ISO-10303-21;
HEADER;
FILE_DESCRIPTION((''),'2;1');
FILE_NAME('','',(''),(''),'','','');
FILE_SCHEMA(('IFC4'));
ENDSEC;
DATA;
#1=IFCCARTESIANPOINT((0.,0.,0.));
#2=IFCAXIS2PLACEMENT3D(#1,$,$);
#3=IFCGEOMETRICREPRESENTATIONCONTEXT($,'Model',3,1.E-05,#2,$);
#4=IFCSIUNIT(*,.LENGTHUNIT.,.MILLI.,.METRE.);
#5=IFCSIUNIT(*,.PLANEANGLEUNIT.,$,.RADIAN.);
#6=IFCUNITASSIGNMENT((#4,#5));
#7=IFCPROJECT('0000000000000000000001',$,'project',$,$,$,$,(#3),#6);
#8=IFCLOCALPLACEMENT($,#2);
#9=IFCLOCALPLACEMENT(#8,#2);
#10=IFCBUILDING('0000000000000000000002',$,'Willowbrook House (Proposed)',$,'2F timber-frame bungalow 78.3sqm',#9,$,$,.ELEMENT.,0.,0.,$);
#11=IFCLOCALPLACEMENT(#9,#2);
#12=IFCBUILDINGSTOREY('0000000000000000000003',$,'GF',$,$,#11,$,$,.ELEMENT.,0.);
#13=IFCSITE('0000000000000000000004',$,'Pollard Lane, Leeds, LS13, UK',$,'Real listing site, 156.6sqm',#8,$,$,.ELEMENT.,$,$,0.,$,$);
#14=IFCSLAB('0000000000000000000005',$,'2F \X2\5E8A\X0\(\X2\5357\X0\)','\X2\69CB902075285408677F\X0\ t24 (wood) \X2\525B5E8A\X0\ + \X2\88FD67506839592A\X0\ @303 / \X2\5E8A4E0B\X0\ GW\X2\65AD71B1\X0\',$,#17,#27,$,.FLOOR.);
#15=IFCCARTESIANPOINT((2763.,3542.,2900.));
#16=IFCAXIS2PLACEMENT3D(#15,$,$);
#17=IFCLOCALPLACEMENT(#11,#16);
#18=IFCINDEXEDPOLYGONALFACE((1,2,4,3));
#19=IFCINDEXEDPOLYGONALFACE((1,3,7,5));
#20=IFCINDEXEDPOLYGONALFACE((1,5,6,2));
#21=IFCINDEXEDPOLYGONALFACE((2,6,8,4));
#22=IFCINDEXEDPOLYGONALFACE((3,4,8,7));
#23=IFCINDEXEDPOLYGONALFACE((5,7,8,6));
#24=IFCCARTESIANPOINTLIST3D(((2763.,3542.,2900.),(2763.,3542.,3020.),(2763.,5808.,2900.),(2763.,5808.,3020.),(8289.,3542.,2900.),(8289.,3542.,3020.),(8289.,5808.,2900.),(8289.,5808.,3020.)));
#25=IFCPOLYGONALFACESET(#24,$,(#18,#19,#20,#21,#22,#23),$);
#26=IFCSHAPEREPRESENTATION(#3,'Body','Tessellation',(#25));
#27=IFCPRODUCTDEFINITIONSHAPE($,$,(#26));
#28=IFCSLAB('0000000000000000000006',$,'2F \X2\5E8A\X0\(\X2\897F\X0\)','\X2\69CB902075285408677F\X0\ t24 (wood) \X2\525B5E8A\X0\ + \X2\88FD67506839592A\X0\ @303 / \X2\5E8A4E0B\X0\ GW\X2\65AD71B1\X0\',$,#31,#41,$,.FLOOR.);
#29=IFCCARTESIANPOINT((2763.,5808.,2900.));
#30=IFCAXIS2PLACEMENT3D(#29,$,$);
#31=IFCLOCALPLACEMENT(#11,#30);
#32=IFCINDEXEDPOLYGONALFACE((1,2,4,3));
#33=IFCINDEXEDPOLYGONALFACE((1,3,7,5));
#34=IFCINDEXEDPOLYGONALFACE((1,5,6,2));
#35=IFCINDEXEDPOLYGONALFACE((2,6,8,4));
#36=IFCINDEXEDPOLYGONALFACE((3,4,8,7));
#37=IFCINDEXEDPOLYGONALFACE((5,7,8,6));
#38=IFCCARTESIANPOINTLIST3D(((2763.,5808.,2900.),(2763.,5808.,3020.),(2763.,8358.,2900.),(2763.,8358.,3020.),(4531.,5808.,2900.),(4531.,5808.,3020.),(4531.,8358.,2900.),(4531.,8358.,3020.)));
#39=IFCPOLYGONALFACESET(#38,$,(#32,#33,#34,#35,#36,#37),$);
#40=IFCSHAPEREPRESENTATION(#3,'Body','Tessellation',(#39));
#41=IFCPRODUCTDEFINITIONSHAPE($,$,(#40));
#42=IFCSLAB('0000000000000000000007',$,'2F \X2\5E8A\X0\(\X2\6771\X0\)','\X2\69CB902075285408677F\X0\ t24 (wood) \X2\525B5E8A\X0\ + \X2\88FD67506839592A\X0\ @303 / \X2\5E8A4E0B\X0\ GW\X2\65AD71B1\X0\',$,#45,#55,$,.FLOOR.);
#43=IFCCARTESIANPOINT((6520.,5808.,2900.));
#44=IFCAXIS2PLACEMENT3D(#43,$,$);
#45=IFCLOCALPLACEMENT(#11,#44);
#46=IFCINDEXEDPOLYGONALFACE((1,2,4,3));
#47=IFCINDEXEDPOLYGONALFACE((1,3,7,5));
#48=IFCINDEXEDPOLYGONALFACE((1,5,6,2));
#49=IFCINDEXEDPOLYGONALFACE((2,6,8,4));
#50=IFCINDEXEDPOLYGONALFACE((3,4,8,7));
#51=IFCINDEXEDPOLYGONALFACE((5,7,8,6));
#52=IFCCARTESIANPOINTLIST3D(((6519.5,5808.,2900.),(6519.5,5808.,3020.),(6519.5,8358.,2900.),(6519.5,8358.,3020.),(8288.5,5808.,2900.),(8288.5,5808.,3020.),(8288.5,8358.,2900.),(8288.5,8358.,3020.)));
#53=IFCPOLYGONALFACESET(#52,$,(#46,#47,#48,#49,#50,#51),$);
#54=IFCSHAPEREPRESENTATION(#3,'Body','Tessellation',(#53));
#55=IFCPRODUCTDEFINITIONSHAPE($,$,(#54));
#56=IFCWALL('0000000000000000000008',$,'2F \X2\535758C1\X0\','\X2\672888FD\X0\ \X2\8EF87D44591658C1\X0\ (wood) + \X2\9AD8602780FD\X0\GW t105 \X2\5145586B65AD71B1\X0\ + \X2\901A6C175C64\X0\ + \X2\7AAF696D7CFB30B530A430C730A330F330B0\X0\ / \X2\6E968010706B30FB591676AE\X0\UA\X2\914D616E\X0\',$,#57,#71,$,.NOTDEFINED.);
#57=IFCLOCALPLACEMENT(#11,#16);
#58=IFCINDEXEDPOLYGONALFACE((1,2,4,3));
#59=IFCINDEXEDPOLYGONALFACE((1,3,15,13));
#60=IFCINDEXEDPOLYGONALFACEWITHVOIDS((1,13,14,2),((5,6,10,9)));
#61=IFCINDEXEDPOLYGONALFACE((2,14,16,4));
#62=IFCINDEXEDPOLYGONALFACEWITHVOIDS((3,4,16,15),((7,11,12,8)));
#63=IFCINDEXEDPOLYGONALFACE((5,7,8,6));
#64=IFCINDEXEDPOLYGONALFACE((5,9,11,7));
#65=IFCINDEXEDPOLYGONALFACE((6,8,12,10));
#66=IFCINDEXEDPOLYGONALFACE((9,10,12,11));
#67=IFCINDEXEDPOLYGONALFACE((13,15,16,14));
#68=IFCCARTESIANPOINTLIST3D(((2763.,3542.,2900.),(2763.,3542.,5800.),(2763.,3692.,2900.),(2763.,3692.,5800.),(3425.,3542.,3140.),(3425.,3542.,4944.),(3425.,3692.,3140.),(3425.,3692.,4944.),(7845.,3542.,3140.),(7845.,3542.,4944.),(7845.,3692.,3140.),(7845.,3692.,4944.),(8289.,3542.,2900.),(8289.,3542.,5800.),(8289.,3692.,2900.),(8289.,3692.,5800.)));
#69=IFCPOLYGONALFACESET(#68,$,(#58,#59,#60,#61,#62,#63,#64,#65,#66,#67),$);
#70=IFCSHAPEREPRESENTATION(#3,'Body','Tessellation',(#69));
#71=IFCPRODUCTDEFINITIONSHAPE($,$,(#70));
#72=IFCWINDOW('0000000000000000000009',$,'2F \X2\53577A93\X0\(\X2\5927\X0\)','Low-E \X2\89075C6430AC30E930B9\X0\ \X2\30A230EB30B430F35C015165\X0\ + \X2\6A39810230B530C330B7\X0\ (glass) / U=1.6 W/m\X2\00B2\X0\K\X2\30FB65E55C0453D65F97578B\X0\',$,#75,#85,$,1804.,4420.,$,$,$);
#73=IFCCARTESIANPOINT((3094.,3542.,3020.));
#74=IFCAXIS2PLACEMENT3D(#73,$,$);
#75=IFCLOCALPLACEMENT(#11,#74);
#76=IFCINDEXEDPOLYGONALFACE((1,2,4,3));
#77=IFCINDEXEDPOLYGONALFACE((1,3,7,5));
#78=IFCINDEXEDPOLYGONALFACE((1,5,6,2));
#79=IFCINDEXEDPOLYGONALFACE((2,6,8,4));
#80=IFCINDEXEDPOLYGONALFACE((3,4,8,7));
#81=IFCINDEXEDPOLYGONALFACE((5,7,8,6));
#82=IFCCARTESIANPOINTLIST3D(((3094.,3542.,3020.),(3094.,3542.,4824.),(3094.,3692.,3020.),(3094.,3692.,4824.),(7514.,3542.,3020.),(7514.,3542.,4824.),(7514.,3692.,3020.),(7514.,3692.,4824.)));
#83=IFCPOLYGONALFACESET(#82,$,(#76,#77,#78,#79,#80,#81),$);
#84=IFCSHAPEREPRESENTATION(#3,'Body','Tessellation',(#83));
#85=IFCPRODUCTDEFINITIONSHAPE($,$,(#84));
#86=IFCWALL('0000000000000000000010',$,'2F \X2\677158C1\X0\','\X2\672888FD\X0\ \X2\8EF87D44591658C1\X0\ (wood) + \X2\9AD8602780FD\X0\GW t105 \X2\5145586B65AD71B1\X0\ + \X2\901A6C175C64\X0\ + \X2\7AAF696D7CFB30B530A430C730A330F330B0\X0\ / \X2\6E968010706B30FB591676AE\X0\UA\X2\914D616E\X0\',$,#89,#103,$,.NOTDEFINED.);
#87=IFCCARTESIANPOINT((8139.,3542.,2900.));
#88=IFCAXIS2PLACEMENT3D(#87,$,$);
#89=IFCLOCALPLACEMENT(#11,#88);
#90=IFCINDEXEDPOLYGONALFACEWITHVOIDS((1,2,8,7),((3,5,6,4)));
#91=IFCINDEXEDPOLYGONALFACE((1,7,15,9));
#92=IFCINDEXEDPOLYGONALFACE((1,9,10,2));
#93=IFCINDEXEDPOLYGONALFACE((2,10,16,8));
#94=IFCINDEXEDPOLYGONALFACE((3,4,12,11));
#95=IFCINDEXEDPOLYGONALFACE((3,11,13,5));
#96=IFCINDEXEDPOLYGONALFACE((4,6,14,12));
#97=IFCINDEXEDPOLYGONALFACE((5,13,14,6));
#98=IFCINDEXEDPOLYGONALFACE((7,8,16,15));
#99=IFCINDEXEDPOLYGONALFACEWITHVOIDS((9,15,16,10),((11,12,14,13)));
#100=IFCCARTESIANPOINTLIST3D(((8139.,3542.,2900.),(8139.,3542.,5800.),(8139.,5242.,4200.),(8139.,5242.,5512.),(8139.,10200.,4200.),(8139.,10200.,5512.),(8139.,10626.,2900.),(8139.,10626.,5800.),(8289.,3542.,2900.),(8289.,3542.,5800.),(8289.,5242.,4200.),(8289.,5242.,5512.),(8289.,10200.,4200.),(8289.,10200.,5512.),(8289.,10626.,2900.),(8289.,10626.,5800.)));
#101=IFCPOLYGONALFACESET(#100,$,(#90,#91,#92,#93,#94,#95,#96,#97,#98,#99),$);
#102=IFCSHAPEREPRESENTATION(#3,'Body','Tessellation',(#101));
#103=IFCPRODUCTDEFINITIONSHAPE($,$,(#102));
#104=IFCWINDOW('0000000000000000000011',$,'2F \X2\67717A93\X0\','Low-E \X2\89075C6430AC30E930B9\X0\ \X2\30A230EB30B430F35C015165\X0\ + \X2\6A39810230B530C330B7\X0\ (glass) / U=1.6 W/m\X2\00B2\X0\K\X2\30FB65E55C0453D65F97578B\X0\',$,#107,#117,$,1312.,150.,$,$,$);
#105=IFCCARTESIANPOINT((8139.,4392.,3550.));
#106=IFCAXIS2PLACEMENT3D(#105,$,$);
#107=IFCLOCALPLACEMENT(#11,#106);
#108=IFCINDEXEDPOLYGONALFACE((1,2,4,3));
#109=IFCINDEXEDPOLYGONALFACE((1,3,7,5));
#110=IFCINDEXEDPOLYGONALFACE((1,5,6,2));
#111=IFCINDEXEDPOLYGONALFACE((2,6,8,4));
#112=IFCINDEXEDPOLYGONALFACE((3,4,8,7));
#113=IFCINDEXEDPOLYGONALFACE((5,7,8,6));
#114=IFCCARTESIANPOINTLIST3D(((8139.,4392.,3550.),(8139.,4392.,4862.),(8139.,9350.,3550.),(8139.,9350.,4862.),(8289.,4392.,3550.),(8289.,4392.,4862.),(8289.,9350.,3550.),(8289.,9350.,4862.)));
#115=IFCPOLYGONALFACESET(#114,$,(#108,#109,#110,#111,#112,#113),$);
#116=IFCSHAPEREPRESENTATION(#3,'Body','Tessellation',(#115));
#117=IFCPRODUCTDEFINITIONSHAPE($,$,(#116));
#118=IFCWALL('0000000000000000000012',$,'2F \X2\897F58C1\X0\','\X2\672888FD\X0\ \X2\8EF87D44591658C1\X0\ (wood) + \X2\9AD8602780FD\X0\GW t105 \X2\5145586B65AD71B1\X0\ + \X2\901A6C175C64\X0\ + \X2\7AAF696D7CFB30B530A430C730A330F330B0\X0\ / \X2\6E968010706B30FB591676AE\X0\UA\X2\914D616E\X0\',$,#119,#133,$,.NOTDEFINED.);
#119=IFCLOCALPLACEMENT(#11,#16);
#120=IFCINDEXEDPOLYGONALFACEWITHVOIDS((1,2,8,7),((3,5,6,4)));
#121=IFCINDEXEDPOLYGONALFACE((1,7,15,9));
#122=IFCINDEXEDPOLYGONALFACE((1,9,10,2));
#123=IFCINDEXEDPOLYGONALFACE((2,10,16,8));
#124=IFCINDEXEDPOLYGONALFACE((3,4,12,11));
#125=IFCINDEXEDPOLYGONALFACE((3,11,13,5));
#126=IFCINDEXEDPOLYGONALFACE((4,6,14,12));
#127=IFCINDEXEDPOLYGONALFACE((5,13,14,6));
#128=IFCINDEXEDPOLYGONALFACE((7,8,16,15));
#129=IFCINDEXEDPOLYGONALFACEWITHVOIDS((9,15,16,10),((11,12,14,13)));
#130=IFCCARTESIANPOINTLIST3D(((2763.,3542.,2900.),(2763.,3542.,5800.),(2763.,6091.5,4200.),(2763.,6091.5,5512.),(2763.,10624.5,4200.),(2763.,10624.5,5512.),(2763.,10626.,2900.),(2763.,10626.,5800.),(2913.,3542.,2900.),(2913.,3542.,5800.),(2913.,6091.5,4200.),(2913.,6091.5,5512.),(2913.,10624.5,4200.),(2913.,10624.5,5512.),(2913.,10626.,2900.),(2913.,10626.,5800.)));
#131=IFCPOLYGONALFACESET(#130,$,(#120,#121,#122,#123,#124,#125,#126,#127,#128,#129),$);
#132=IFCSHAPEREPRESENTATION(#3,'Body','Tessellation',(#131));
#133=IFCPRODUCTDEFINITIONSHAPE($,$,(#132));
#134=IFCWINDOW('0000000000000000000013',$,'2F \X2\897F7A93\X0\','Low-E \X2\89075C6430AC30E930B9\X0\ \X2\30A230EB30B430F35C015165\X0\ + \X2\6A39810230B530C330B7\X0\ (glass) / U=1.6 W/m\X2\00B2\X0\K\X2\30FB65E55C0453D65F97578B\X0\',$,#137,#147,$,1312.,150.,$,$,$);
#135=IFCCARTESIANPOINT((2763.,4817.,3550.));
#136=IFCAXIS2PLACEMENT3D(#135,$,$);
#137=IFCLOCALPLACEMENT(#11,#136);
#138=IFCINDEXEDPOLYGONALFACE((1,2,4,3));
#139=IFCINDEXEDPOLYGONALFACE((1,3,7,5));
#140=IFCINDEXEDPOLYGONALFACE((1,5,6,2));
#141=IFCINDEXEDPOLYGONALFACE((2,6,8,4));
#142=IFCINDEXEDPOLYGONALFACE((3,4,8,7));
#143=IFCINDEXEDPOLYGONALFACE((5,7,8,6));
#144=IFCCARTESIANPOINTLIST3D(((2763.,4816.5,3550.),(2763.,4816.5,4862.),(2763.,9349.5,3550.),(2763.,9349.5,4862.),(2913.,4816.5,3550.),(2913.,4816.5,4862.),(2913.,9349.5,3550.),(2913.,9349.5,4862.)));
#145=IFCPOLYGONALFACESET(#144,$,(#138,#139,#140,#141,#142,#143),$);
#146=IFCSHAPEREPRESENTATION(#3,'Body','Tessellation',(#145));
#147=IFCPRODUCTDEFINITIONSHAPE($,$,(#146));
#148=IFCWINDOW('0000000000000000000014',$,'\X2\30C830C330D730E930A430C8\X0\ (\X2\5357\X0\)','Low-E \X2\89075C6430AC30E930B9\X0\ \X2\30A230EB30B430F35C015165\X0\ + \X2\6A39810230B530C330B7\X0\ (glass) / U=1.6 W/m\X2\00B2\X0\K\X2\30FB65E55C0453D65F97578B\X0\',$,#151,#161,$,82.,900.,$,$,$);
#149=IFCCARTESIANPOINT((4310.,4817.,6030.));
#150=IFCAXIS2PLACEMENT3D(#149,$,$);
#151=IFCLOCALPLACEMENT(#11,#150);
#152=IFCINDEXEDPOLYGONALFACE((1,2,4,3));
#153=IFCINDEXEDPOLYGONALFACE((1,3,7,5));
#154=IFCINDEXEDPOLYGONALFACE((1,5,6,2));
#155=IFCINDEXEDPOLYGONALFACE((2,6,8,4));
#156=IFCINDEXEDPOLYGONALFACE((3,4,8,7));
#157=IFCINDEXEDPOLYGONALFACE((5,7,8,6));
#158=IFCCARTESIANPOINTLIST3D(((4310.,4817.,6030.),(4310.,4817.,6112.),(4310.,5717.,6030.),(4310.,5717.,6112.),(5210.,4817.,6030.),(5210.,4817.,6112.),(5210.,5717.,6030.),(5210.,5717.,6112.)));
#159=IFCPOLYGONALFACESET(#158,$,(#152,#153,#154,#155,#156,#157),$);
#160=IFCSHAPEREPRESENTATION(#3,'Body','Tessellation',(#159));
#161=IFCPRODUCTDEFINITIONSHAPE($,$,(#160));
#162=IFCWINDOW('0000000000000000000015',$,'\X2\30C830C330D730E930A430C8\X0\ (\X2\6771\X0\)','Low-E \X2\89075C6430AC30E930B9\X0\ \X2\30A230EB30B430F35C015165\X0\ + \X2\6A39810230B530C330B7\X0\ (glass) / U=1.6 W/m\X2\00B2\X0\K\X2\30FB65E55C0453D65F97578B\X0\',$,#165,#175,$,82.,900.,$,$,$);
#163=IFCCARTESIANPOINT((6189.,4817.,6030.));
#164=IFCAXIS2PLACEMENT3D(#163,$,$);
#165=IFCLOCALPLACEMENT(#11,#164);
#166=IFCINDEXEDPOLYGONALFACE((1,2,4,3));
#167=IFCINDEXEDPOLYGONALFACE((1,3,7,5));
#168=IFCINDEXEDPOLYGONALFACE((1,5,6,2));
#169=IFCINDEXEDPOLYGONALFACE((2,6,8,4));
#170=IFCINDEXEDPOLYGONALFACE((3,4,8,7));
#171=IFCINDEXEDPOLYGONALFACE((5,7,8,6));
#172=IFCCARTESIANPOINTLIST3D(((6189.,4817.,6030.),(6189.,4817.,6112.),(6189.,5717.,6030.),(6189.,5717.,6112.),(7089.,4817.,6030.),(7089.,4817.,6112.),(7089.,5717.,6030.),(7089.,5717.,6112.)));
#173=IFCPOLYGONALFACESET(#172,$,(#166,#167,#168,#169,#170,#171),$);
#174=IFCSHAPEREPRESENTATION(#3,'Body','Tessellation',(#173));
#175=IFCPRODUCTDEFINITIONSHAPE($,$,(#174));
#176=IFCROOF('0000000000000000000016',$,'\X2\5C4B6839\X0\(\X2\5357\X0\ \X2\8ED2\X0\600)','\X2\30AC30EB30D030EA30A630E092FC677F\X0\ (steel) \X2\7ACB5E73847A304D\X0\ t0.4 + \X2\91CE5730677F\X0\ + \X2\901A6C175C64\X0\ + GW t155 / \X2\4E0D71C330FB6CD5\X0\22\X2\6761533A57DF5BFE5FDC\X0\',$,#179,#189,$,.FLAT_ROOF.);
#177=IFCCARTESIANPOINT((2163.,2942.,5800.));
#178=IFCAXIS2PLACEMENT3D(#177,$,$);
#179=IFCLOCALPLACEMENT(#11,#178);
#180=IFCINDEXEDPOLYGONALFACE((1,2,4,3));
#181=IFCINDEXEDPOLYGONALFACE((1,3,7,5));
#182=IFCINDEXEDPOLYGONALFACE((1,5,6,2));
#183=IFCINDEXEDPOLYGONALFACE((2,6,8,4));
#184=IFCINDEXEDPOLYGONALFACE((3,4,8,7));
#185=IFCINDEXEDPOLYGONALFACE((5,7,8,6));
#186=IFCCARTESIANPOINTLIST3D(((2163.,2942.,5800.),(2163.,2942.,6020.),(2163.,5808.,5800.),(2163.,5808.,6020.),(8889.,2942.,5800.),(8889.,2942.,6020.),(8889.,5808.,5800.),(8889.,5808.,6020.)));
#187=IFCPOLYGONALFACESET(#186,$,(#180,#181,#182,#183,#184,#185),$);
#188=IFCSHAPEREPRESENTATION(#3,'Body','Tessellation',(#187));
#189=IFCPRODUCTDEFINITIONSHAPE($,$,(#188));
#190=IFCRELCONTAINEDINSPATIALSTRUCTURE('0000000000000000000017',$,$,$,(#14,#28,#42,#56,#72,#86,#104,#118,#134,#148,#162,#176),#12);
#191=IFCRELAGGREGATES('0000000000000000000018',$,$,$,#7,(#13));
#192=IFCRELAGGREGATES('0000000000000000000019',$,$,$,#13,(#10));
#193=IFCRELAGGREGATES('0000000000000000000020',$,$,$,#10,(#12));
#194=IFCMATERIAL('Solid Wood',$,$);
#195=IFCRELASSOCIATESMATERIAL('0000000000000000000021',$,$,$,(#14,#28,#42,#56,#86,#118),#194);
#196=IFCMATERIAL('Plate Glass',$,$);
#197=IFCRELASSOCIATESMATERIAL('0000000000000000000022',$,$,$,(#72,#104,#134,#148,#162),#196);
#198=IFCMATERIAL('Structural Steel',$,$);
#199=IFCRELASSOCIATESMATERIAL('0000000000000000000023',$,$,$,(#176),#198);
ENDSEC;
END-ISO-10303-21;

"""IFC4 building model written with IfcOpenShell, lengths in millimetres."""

from ifc_helpers import new_model, si_unit, frame, frame_2d, origin, place, context, project, spatial, rectangle, extrude, material, element, fill, save


model = new_model("IFC4")

# Units and contexts
model_context = context("Model", 3, precision=1e-05, world=origin())
ifc_project = project(units=[si_unit("LENGTHUNIT", "METRE", prefix="MILLI"), si_unit("PLANEANGLEUNIT", "RADIAN")], contexts=[model_context])

# Site, building, storey
site_placement = place(None, origin())
site = spatial("IfcSite", under=ifc_project, at=site_placement, Name="Pollard Lane, Leeds, LS13, UK", ObjectType="Real listing site, 156.6sqm", CompositionType="ELEMENT", RefElevation=0.0)
building_placement = place(site_placement, origin())
building = spatial("IfcBuilding", under=site, at=building_placement, Name="Willowbrook House (Proposed)", ObjectType="2F timber-frame bungalow 78.3sqm", CompositionType="ELEMENT", ElevationOfRefHeight=0.0, ElevationOfTerrain=0.0)
storey_placement = place(building_placement, origin())
storey = spatial("IfcBuildingStorey", under=building, at=storey_placement, Name="GF", CompositionType="ELEMENT", Elevation=0.0)

# Slabs
ifc_material_1 = material(Name="Solid Wood")
slab_1_placement = place(storey_placement, frame((2763.0, 3542.0, 2900.0)))
element("IfcSlab", 1, at=slab_1_placement, inside=storey, material=ifc_material_1, Name="2F 床(南)", Description="構造用合板 t24 (wood) 剛床 + 製材根太 @303 / 床下 GW断熱", PredefinedType="FLOOR", context=model_context, shape_type="SweptSolid", body=[
    extrude(rectangle(XDim=5526.0, YDim=2266.0, at=frame_2d((2763.0, 1133.0))), frame((2763.0, 3542.0, 2900.0)), (0.0, 0.0, 1.0), 120.0),
])
slab_2_placement = place(storey_placement, frame((2763.0, 5808.0, 2900.0)))
element("IfcSlab", 2, at=slab_2_placement, inside=storey, material=ifc_material_1, Name="2F 床(西)", Description="構造用合板 t24 (wood) 剛床 + 製材根太 @303 / 床下 GW断熱", PredefinedType="FLOOR", context=model_context, shape_type="SweptSolid", body=[
    extrude(rectangle(XDim=1768.0, YDim=2550.0, at=frame_2d((884.0, 1275.0))), frame((2763.0, 5808.0, 2900.0)), (0.0, 0.0, 1.0), 120.0),
])
slab_3_placement = place(storey_placement, frame((6520.0, 5808.0, 2900.0)))
element("IfcSlab", 3, at=slab_3_placement, inside=storey, material=ifc_material_1, Name="2F 床(東)", Description="構造用合板 t24 (wood) 剛床 + 製材根太 @303 / 床下 GW断熱", PredefinedType="FLOOR", context=model_context, shape_type="SweptSolid", body=[
    extrude(rectangle(XDim=1769.0, YDim=2550.0, at=frame_2d((884.0, 1275.0))), frame((6520.0, 5808.0, 2900.0)), (0.0, 0.0, 1.0), 120.0),
])

# Walls, openings, windows
wall_1_placement = place(storey_placement, frame((2763.0, 3542.0, 2900.0)))
wall_1 = element("IfcWall", 4, at=wall_1_placement, inside=storey, material=ifc_material_1, Name="2F 南壁", Description="木製 軸組外壁 (wood) + 高性能GW t105 充填断熱 + 通気層 + 窯業系サイディング / 準耐火・外皮UA配慮", PredefinedType="NOTDEFINED", context=model_context, shape_type="SweptSolid", body=[
    extrude(rectangle(XDim=5526.0, YDim=150.0, at=frame_2d((2763.0, 75.0))), frame((2763.0, 3542.0, 2900.0)), (0.0, 0.0, 1.0), 2900.0),
])
opening_1_placement = place(storey_placement, frame((3094.0, 3542.0, 3020.0)))
opening_1 = element("IfcOpeningElement", 5, at=opening_1_placement, cuts=wall_1, PredefinedType="NOTDEFINED", context=model_context, shape_type="SweptSolid", body=[
    extrude(rectangle(XDim=4420.0, YDim=150.0, at=frame_2d((2210.0, 75.0))), frame((3094.0, 3542.0, 3020.0)), (0.0, 0.0, 1.0), 1804.0),
])
ifc_material_2 = material(Name="Plate Glass")
window_1_placement = place(storey_placement, frame((3094.0, 3542.0, 3020.0)))
window_1 = element("IfcWindow", 6, at=window_1_placement, inside=storey, material=ifc_material_2, Name="2F 南窓(大)", Description="Low-E 複層ガラス アルゴン封入 + 樹脂サッシ (glass) / U=1.6 W/m²K・日射取得型", OverallHeight=1804.0, OverallWidth=4420.0, context=model_context, shape_type="SweptSolid", body=[
    extrude(rectangle(XDim=4420.0, YDim=150.0, at=frame_2d((2210.0, 75.0))), frame((3094.0, 3542.0, 3020.0)), (0.0, 0.0, 1.0), 1804.0),
])
fill(opening_1, window_1)
wall_2_placement = place(storey_placement, frame((8139.0, 3542.0, 2900.0)))
wall_2 = element("IfcWall", 7, at=wall_2_placement, inside=storey, material=ifc_material_1, Name="2F 東壁", Description="木製 軸組外壁 (wood) + 高性能GW t105 充填断熱 + 通気層 + 窯業系サイディング / 準耐火・外皮UA配慮", PredefinedType="NOTDEFINED", context=model_context, shape_type="SweptSolid", body=[
    extrude(rectangle(XDim=150.0, YDim=7084.0, at=frame_2d((75.0, 3542.0))), frame((8139.0, 3542.0, 2900.0)), (0.0, 0.0, 1.0), 2900.0),
])
opening_2_placement = place(storey_placement, frame((8139.0, 4392.0, 3550.0)))
opening_2 = element("IfcOpeningElement", 8, at=opening_2_placement, cuts=wall_2, PredefinedType="NOTDEFINED", context=model_context, shape_type="SweptSolid", body=[
    extrude(rectangle(XDim=150.0, YDim=4958.0, at=frame_2d((75.0, 2479.0))), frame((8139.0, 4392.0, 3550.0)), (0.0, 0.0, 1.0), 1312.0),
])
window_2_placement = place(storey_placement, frame((8139.0, 4392.0, 3550.0)))
window_2 = element("IfcWindow", 9, at=window_2_placement, inside=storey, material=ifc_material_2, Name="2F 東窓", Description="Low-E 複層ガラス アルゴン封入 + 樹脂サッシ (glass) / U=1.6 W/m²K・日射取得型", OverallHeight=1312.0, OverallWidth=150.0, context=model_context, shape_type="SweptSolid", body=[
    extrude(rectangle(XDim=150.0, YDim=4958.0, at=frame_2d((75.0, 2479.0))), frame((8139.0, 4392.0, 3550.0)), (0.0, 0.0, 1.0), 1312.0),
])
fill(opening_2, window_2)
wall_3_placement = place(storey_placement, frame((2763.0, 3542.0, 2900.0)))
wall_3 = element("IfcWall", 10, at=wall_3_placement, inside=storey, material=ifc_material_1, Name="2F 西壁", Description="木製 軸組外壁 (wood) + 高性能GW t105 充填断熱 + 通気層 + 窯業系サイディング / 準耐火・外皮UA配慮", PredefinedType="NOTDEFINED", context=model_context, shape_type="SweptSolid", body=[
    extrude(rectangle(XDim=150.0, YDim=7084.0, at=frame_2d((75.0, 3542.0))), frame((2763.0, 3542.0, 2900.0)), (0.0, 0.0, 1.0), 2900.0),
])
opening_3_placement = place(storey_placement, frame((2763.0, 4817.0, 3550.0)))
opening_3 = element("IfcOpeningElement", 11, at=opening_3_placement, cuts=wall_3, PredefinedType="NOTDEFINED", context=model_context, shape_type="SweptSolid", body=[
    extrude(rectangle(XDim=150.0, YDim=4533.0, at=frame_2d((75.0, 2266.0))), frame((2763.0, 4817.0, 3550.0)), (0.0, 0.0, 1.0), 1312.0),
])
window_3_placement = place(storey_placement, frame((2763.0, 4817.0, 3550.0)))
window_3 = element("IfcWindow", 12, at=window_3_placement, inside=storey, material=ifc_material_2, Name="2F 西窓", Description="Low-E 複層ガラス アルゴン封入 + 樹脂サッシ (glass) / U=1.6 W/m²K・日射取得型", OverallHeight=1312.0, OverallWidth=150.0, context=model_context, shape_type="SweptSolid", body=[
    extrude(rectangle(XDim=150.0, YDim=4533.0, at=frame_2d((75.0, 2266.0))), frame((2763.0, 4817.0, 3550.0)), (0.0, 0.0, 1.0), 1312.0),
])
fill(opening_3, window_3)

# Windows
window_4_placement = place(storey_placement, frame((4310.0, 4817.0, 6030.0)))
element("IfcWindow", 13, at=window_4_placement, inside=storey, material=ifc_material_2, Name="トップライト (南)", Description="Low-E 複層ガラス アルゴン封入 + 樹脂サッシ (glass) / U=1.6 W/m²K・日射取得型", OverallHeight=82.0, OverallWidth=900.0, context=model_context, shape_type="SweptSolid", body=[
    extrude(rectangle(XDim=900.0, YDim=900.0, at=frame_2d((450.0, 450.0))), frame((4310.0, 4817.0, 6030.0)), (0.0, 0.0, 1.0), 82.0),
])
window_5_placement = place(storey_placement, frame((6189.0, 4817.0, 6030.0)))
element("IfcWindow", 14, at=window_5_placement, inside=storey, material=ifc_material_2, Name="トップライト (東)", Description="Low-E 複層ガラス アルゴン封入 + 樹脂サッシ (glass) / U=1.6 W/m²K・日射取得型", OverallHeight=82.0, OverallWidth=900.0, context=model_context, shape_type="SweptSolid", body=[
    extrude(rectangle(XDim=900.0, YDim=900.0, at=frame_2d((450.0, 450.0))), frame((6189.0, 4817.0, 6030.0)), (0.0, 0.0, 1.0), 82.0),
])

# Roof
ifc_material_3 = material(Name="Structural Steel")
roof_1_placement = place(storey_placement, frame((2163.0, 2942.0, 5800.0)))
element("IfcRoof", 15, at=roof_1_placement, inside=storey, material=ifc_material_3, Name="屋根(南 軒600)", Description="ガルバリウム鋼板 (steel) 立平葺き t0.4 + 野地板 + 通気層 + GW t155 / 不燃・法22条区域対応", PredefinedType="FLAT_ROOF", context=model_context, shape_type="SweptSolid", body=[
    extrude(rectangle(XDim=6726.0, YDim=2866.0, at=frame_2d((3363.0, 1433.0))), frame((2163.0, 2942.0, 5800.0)), (0.0, 0.0, 1.0), 220.0),
])

save(model, "model.ifc")
